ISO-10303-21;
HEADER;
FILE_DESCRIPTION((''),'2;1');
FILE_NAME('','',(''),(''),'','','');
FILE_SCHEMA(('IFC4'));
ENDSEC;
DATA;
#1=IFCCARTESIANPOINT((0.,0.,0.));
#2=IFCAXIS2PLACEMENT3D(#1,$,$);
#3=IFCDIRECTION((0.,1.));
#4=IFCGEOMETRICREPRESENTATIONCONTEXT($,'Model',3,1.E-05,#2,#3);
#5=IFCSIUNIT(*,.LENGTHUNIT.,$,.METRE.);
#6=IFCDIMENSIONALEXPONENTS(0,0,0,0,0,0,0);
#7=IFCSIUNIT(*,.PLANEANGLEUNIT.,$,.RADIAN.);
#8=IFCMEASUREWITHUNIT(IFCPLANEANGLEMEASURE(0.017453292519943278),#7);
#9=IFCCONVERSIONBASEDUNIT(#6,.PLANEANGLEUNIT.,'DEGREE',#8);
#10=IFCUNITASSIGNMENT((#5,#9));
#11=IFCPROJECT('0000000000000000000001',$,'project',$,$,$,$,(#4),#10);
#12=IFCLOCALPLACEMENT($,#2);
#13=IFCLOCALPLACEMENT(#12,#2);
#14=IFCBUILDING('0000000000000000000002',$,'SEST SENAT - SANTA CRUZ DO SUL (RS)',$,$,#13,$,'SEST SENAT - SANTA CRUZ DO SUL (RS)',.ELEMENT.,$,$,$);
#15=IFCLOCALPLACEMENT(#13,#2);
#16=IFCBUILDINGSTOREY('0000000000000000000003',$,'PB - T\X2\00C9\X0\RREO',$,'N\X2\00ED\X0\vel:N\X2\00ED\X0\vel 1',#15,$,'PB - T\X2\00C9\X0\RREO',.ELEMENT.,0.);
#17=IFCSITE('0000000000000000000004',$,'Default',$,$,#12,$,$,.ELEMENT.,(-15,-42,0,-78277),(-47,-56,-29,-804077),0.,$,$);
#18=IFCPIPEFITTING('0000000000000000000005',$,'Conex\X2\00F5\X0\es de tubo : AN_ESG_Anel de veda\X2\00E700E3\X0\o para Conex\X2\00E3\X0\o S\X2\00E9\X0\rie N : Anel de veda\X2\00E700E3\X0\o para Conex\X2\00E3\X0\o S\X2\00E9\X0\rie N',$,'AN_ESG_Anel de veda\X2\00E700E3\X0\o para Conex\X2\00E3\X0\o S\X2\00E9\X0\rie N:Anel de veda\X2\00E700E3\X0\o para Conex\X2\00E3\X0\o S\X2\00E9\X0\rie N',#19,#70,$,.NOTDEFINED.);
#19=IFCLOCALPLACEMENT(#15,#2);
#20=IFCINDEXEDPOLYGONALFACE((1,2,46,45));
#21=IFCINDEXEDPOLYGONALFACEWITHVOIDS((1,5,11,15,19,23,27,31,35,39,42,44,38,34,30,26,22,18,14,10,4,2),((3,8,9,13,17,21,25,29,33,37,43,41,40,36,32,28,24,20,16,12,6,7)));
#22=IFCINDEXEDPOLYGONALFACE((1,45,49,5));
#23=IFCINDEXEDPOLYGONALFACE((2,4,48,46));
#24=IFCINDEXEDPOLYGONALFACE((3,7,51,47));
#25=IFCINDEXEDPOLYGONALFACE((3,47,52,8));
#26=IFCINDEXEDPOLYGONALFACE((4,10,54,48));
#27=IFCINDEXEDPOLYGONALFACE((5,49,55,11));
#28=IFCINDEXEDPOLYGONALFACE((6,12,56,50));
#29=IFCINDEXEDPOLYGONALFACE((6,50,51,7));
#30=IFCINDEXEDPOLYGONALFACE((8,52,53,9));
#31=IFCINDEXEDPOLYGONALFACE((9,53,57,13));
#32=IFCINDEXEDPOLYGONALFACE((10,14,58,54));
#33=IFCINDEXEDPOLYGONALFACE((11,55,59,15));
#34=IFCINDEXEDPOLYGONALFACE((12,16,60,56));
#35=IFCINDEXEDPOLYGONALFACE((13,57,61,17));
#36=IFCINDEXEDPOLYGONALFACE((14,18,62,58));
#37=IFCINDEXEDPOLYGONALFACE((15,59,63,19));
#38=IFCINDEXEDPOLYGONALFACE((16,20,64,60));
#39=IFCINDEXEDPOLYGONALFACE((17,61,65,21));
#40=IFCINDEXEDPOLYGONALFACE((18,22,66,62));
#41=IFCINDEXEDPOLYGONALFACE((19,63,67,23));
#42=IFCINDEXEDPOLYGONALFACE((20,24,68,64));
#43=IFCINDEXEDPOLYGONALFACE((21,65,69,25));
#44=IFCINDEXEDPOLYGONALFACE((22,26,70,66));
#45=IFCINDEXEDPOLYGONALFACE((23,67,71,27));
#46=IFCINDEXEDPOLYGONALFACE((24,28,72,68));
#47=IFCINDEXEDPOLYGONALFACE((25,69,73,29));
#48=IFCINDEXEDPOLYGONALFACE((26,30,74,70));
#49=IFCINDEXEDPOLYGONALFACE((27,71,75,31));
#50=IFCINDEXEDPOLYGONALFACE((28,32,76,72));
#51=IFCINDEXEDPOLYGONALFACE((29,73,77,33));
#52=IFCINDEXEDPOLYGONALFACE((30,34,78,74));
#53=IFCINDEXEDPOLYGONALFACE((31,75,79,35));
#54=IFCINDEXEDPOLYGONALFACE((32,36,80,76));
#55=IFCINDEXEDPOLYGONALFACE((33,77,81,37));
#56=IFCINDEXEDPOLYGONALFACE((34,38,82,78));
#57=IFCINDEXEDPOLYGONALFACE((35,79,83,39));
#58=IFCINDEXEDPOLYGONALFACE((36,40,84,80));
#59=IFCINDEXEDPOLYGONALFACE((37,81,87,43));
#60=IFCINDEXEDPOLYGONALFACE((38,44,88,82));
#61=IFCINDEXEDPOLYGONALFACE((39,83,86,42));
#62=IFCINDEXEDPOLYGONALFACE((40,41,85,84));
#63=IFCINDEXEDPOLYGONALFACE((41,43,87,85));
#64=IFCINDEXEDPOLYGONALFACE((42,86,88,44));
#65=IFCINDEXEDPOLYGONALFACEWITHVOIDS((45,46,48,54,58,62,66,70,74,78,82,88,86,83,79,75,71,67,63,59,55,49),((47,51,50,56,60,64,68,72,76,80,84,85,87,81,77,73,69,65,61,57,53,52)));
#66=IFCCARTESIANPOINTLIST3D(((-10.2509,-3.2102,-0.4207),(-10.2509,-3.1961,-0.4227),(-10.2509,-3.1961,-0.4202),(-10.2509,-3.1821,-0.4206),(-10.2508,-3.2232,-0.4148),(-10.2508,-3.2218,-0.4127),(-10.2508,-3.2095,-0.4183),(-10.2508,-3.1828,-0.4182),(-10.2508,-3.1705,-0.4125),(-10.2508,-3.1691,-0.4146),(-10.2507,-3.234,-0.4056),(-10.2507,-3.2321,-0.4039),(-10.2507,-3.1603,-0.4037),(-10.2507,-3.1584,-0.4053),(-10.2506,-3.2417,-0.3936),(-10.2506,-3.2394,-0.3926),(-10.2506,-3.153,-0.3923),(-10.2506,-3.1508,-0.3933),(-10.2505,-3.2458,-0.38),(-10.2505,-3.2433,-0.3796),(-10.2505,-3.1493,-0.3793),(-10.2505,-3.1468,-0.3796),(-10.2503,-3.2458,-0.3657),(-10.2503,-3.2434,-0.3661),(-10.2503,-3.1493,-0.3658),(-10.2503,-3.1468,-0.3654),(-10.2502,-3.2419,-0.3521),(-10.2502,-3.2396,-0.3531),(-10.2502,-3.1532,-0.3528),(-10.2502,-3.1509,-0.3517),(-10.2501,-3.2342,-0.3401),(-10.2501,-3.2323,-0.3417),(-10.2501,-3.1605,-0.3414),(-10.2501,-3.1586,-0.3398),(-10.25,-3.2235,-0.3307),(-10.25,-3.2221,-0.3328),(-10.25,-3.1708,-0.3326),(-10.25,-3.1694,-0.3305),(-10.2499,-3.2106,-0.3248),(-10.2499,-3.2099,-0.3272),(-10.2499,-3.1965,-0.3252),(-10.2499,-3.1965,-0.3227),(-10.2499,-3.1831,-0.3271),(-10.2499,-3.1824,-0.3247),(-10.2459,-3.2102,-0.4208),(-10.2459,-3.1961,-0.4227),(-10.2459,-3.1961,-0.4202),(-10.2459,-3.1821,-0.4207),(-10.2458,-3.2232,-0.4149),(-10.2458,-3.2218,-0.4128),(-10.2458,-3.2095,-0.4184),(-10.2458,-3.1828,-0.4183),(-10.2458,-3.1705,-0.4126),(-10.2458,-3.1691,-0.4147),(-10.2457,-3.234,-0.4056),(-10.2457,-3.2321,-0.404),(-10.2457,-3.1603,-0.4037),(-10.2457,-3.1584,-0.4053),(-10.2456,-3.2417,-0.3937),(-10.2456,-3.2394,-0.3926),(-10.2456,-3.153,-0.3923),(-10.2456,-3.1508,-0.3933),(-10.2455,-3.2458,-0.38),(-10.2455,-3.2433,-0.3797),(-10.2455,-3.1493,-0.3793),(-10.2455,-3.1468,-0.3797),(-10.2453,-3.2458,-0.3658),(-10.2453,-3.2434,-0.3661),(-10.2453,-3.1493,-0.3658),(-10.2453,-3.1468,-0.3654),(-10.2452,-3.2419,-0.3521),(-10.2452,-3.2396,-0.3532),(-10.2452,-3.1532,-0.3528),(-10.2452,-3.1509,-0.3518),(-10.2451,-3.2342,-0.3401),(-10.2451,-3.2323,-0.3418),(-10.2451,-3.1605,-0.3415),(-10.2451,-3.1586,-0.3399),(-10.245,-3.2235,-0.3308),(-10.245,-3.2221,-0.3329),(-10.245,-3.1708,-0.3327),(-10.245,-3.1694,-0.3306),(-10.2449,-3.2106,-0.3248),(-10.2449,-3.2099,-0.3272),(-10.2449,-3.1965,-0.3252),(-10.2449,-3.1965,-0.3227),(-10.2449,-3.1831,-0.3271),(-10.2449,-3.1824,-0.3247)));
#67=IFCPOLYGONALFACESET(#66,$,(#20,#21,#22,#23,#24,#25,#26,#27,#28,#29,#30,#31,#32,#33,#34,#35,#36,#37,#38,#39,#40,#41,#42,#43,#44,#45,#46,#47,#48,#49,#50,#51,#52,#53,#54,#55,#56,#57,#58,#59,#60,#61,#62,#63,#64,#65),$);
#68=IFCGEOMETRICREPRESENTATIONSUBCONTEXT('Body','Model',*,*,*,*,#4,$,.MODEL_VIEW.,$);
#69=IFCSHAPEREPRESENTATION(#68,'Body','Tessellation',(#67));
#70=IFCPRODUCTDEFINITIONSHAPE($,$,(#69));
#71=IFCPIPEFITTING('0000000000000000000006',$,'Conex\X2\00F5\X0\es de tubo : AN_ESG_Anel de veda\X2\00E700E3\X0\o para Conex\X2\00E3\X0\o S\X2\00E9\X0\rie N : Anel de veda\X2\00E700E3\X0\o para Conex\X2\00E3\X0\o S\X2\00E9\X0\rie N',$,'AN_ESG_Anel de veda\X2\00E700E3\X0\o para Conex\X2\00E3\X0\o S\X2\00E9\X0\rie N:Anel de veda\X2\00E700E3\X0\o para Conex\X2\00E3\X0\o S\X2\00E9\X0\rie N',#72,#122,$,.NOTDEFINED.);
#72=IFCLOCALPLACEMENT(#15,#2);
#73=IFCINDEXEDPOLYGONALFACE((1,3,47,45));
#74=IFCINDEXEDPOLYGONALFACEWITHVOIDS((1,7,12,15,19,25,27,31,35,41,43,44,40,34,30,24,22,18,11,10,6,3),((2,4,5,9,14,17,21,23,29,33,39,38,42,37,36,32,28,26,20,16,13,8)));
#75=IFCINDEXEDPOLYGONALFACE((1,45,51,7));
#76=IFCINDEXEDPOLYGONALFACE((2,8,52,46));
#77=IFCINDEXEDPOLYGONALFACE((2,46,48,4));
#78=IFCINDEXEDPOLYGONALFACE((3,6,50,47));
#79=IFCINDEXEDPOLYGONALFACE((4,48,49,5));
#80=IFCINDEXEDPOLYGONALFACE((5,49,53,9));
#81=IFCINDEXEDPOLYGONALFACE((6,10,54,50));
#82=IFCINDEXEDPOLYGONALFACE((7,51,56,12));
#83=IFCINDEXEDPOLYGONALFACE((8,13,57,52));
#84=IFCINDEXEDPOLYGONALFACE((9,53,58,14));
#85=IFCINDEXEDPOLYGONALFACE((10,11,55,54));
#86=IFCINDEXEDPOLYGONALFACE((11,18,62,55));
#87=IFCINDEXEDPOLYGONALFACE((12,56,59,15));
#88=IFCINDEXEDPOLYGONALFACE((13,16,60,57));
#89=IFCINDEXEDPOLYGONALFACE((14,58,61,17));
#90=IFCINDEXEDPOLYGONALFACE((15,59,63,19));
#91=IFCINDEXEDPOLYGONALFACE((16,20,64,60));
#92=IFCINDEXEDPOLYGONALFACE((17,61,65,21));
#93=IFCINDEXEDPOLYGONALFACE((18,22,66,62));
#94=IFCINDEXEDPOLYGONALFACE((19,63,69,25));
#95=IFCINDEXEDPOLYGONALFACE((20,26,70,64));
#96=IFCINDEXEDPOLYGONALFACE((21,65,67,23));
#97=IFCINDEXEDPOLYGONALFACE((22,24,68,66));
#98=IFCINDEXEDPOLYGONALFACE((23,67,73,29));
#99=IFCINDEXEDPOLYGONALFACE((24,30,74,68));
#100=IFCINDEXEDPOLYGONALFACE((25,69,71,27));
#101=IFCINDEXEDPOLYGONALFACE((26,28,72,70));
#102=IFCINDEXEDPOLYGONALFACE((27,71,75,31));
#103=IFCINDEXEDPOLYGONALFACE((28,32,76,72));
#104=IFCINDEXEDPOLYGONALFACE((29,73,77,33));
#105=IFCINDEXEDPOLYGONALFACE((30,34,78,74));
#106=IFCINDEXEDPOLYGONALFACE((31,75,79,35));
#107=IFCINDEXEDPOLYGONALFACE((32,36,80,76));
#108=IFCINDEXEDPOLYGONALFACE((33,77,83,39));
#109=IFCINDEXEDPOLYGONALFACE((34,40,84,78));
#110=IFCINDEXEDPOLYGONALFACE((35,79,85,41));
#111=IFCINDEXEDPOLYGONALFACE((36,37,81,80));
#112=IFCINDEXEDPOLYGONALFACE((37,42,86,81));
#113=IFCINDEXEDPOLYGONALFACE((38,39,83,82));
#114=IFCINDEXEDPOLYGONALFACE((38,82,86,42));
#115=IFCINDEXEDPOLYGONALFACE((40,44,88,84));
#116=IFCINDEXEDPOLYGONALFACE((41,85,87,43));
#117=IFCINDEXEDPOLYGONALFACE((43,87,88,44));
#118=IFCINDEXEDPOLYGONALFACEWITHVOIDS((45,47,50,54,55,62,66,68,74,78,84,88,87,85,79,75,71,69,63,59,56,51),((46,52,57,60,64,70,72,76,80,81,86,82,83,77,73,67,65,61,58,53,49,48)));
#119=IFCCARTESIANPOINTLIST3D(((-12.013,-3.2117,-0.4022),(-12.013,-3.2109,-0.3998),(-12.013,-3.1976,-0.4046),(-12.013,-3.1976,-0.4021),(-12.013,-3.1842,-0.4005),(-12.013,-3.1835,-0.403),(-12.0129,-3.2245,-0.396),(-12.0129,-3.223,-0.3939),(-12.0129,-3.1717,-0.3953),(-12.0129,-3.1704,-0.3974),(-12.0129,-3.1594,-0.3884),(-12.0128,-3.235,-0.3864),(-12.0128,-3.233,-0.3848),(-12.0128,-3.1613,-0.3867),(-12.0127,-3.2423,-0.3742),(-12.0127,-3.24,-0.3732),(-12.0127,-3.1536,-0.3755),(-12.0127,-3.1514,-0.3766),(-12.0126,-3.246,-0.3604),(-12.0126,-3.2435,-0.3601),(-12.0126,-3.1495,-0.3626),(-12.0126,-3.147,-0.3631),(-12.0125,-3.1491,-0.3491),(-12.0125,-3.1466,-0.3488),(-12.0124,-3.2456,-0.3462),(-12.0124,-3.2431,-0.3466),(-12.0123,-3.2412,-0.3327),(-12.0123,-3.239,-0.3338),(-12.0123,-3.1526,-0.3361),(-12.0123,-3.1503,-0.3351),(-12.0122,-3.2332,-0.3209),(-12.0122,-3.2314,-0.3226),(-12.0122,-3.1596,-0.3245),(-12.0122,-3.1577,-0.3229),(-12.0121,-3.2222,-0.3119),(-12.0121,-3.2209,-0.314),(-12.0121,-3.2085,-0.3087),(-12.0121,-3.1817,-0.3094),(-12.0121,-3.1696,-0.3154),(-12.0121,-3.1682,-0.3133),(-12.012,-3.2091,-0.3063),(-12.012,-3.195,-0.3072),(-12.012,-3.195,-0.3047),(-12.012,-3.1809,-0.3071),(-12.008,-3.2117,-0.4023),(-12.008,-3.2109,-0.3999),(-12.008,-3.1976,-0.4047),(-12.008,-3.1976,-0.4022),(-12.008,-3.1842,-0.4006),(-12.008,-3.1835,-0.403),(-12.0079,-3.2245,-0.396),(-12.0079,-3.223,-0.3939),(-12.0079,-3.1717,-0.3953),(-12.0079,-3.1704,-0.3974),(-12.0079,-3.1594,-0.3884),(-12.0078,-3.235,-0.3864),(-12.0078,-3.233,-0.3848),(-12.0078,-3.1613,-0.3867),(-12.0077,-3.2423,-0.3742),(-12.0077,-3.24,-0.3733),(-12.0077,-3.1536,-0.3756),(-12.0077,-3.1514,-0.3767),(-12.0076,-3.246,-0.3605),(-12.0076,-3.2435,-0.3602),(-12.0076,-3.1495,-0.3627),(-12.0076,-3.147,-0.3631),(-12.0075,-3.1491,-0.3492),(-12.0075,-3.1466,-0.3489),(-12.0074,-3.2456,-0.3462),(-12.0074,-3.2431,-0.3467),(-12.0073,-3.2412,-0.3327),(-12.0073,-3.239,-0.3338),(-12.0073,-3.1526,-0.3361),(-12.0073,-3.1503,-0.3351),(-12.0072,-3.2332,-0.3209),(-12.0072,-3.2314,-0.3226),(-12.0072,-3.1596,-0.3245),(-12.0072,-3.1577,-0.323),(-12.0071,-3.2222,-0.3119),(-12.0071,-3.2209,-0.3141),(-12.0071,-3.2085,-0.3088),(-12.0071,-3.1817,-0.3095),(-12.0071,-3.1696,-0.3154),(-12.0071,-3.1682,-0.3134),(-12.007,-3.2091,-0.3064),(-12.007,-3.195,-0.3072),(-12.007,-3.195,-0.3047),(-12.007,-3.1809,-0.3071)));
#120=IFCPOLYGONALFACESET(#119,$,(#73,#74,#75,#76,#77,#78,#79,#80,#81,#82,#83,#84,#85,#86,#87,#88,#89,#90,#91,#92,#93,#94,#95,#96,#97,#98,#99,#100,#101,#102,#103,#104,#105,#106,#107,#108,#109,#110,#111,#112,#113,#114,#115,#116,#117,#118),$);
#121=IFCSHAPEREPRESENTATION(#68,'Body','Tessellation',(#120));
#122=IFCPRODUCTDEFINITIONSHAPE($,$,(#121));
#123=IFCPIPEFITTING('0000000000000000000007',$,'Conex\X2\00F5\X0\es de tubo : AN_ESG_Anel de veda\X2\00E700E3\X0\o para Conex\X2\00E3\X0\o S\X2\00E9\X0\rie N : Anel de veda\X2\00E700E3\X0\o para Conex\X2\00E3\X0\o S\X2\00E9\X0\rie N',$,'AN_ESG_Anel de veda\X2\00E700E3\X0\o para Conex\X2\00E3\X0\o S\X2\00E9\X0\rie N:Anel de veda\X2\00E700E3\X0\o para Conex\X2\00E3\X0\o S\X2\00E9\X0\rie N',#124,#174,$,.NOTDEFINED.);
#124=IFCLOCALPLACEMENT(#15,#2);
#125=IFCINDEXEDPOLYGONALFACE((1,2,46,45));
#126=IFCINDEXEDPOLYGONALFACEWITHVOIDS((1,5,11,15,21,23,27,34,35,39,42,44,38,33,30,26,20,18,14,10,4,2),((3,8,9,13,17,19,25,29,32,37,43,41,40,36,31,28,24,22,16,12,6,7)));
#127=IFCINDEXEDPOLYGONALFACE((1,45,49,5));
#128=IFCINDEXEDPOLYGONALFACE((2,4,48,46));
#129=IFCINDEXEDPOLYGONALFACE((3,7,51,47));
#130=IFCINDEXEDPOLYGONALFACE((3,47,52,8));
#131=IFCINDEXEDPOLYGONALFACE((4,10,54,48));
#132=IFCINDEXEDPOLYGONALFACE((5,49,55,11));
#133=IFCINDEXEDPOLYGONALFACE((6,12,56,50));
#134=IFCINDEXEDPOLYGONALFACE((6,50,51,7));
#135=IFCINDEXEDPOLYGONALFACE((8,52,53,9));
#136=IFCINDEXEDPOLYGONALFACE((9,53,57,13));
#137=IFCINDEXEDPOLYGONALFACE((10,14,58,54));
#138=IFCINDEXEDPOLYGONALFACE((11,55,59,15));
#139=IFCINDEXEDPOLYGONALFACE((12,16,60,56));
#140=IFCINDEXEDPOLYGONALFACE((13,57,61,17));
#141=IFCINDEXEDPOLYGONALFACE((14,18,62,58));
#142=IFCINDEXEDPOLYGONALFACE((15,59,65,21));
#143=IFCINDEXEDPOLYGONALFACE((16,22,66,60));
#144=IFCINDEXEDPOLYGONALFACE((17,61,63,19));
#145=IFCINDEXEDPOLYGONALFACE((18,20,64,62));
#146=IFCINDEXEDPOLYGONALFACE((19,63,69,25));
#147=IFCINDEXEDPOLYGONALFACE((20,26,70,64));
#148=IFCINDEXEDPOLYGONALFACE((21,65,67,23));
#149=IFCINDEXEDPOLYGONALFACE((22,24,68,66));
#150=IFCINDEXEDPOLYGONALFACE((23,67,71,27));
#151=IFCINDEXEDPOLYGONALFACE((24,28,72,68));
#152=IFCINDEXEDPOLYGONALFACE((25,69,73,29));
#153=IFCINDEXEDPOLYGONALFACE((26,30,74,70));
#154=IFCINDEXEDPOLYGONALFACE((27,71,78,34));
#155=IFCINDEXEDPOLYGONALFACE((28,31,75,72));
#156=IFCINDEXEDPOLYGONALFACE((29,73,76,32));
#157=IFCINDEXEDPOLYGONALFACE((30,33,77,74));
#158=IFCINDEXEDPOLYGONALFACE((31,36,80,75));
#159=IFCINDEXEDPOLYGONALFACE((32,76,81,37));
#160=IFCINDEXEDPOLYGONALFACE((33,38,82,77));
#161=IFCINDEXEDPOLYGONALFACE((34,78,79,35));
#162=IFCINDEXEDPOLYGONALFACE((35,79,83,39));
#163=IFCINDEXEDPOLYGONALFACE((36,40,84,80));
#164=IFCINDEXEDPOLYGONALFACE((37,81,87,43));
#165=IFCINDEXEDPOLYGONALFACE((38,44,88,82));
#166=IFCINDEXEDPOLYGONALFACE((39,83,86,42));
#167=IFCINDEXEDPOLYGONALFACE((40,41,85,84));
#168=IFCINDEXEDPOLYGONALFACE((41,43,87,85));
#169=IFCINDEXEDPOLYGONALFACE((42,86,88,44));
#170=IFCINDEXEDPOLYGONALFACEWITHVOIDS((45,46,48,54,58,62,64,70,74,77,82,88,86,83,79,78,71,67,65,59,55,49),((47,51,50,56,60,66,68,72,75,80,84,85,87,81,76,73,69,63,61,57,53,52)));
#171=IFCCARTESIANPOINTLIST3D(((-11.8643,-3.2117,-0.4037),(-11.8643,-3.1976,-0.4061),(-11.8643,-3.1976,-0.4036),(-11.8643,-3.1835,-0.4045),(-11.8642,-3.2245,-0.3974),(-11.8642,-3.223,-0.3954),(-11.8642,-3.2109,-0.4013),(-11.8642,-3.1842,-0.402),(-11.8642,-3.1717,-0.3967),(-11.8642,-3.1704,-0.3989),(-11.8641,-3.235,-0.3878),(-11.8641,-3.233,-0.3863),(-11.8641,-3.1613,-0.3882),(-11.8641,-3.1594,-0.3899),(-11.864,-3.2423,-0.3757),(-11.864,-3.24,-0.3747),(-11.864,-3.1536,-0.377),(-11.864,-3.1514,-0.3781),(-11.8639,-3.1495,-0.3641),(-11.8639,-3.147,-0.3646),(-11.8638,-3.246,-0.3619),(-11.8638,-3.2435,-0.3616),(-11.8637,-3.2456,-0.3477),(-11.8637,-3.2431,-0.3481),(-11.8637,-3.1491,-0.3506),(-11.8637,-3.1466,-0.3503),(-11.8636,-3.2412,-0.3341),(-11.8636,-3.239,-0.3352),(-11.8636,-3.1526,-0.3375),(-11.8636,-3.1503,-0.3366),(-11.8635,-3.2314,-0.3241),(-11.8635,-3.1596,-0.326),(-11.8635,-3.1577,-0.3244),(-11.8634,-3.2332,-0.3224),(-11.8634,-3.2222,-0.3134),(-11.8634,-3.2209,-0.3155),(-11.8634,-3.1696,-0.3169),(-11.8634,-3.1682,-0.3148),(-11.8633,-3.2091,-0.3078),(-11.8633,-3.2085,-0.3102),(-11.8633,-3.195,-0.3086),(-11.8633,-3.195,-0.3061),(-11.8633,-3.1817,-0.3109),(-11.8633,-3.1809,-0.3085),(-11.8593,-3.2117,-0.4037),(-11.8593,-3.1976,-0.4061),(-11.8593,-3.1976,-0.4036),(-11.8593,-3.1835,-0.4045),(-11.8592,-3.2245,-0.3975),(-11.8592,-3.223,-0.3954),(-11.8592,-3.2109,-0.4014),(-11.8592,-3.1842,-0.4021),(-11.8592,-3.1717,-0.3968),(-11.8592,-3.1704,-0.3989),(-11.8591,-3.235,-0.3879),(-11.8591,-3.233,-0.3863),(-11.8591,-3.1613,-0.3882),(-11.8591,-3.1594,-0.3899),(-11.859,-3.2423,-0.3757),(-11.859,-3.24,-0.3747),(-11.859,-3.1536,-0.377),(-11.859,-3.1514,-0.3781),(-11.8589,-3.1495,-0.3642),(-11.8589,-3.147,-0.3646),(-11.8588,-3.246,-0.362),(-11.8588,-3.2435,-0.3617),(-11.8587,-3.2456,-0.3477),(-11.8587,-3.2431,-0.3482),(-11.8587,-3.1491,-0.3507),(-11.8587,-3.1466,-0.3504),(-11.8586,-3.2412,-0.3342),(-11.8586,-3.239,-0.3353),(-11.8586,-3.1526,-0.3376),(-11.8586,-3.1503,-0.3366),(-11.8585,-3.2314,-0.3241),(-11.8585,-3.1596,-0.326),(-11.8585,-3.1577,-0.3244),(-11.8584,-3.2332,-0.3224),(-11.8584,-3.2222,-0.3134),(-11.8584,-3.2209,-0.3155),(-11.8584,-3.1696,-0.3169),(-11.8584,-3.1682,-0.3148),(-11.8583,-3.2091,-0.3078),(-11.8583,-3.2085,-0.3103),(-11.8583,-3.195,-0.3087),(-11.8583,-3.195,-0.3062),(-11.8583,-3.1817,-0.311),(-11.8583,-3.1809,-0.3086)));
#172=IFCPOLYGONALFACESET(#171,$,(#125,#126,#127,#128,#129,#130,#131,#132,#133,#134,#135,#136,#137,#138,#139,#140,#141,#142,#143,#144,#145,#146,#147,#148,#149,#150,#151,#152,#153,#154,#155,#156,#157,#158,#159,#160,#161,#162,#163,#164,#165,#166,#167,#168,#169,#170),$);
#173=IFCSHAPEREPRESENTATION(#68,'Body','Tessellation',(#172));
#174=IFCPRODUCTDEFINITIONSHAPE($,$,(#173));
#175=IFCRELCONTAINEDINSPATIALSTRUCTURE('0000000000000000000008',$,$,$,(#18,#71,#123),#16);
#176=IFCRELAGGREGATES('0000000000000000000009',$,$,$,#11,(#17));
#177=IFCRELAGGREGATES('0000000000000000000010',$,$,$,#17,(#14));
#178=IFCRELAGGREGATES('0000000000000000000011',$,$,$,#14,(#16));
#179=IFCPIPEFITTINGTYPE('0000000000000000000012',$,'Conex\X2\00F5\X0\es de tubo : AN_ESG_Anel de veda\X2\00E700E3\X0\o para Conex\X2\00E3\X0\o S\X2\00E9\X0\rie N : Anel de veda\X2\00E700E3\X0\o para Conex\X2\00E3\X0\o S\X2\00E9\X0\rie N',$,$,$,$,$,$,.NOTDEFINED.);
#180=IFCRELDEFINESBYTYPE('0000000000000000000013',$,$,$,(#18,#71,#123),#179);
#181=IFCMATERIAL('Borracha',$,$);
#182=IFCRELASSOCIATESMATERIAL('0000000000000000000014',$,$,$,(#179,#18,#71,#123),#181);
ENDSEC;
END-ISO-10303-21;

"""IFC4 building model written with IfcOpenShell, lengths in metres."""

from ifc_helpers import new_model, entity, si_unit, converted_unit, direction, frame, origin, place, context, subcontext, project, spatial, arc, indexed_curve, outline, extrude, source, transform, mapped, material, type_object, type_shapes, element, save


model = new_model("IFC4")

# Units and contexts
model_context = context("Model", 3, precision=1e-05, world=origin(), true_north=direction((0.0, 1.0)))
body_context = subcontext(model_context, "Body", "Model", "MODEL_VIEW")
ifc_project = project(units=[si_unit("LENGTHUNIT", "METRE"), converted_unit("PLANEANGLEUNIT", "DEGREE", entity("IfcPlaneAngleMeasure", 0.017453292519943278), si_unit("PLANEANGLEUNIT", "RADIAN"), dimensions=[0, 0, 0, 0, 0, 0, 0])], contexts=[model_context])

# Site, building, storey
site_placement = place(None, origin())
site = spatial("IfcSite", under=ifc_project, at=site_placement, Name="Default", CompositionType="ELEMENT", RefLatitude=(-15, -42, 0, -78277), RefLongitude=(-47, -56, -29, -804077), RefElevation=0.0)
building_placement = place(site_placement, origin())
building = spatial("IfcBuilding", under=site, at=building_placement, Name="SEST SENAT - SANTA CRUZ DO SUL (RS)", LongName="SEST SENAT - SANTA CRUZ DO SUL (RS)", CompositionType="ELEMENT")
storey_placement = place(building_placement, origin())
storey = spatial("IfcBuildingStorey", under=building, at=storey_placement, Name="PB - TÉRREO", ObjectType="Nível:Nível 1", LongName="PB - TÉRREO", CompositionType="ELEMENT", Elevation=0.0)

# Pipe fittings
ifc_material = material(Name="Borracha")
pipe_fitting_type_1 = type_object("IfcPipeFittingType", Name="Conexões de tubo : AN_ESG_Anel de vedação para Conexão Série N : Anel de vedação para Conexão Série N", PredefinedType="NOTDEFINED", material=ifc_material)
shared_shape_1 = source(origin(), body_context, "Body", "SweptSolid", [
    extrude(outline(indexed_curve([(-0.05, 0.0), (0.0, -0.05), (0.05, 0.0), (0.0, 0.05)], segments=[arc(1, 2, 3), arc(3, 4, 1)], self_intersect=False), holes=[indexed_curve([(-0.0475, 0.0), (0.0, 0.0475), (0.0475, 0.0), (0.0, -0.0475)], segments=[arc(1, 2, 3), arc(3, 4, 1)], self_intersect=False)]), frame((0.0, 0.0, -0.005)), (0.0, 0.0, 1.0), 0.005),
])
type_shapes(pipe_fitting_type_1, [shared_shape_1])
for number, where, z_axis, x_axis, name in (
    (1, (-10.2454, -3.1963, -0.3727), (0.99995, 0.0, -0.01), (0.009999, -0.003595, 0.999944), "Conexões de tubo : AN_ESG_Anel de vedação para Conexão Série N : Anel de vedação para Conexão Série N"),
    (2, (-12.0075, -3.1963, -0.3547), (0.99995, 0.0, -0.01), (0.009996, 0.026708, 0.999593), "Conexões de tubo : AN_ESG_Anel de vedação para Conexão Série N : Anel de vedação para Conexão Série N"),
    (3, (-11.8638, -3.1963, -0.3561), (-0.99995, 0.0, 0.01), (0.009996, 0.026708, 0.999593), "Conexões de tubo : AN_ESG_Anel de vedação para Conexão Série N : Anel de vedação para Conexão Série N"),
):
    element("IfcPipeFitting", number, at=place(storey_placement, frame(where, z_axis=z_axis, x_axis=x_axis)), inside=storey, type_object=pipe_fitting_type_1, material=ifc_material, Name=name, ObjectType="AN_ESG_Anel de vedação para Conexão Série N:Anel de vedação para Conexão Série N", PredefinedType="NOTDEFINED", context=body_context, shape_type="MappedRepresentation", body=[
        mapped(shared_shape_1, transform((0.0, 0.0, 0.0), scale=1.0)),
    ])

save(model, "model.ifc")
